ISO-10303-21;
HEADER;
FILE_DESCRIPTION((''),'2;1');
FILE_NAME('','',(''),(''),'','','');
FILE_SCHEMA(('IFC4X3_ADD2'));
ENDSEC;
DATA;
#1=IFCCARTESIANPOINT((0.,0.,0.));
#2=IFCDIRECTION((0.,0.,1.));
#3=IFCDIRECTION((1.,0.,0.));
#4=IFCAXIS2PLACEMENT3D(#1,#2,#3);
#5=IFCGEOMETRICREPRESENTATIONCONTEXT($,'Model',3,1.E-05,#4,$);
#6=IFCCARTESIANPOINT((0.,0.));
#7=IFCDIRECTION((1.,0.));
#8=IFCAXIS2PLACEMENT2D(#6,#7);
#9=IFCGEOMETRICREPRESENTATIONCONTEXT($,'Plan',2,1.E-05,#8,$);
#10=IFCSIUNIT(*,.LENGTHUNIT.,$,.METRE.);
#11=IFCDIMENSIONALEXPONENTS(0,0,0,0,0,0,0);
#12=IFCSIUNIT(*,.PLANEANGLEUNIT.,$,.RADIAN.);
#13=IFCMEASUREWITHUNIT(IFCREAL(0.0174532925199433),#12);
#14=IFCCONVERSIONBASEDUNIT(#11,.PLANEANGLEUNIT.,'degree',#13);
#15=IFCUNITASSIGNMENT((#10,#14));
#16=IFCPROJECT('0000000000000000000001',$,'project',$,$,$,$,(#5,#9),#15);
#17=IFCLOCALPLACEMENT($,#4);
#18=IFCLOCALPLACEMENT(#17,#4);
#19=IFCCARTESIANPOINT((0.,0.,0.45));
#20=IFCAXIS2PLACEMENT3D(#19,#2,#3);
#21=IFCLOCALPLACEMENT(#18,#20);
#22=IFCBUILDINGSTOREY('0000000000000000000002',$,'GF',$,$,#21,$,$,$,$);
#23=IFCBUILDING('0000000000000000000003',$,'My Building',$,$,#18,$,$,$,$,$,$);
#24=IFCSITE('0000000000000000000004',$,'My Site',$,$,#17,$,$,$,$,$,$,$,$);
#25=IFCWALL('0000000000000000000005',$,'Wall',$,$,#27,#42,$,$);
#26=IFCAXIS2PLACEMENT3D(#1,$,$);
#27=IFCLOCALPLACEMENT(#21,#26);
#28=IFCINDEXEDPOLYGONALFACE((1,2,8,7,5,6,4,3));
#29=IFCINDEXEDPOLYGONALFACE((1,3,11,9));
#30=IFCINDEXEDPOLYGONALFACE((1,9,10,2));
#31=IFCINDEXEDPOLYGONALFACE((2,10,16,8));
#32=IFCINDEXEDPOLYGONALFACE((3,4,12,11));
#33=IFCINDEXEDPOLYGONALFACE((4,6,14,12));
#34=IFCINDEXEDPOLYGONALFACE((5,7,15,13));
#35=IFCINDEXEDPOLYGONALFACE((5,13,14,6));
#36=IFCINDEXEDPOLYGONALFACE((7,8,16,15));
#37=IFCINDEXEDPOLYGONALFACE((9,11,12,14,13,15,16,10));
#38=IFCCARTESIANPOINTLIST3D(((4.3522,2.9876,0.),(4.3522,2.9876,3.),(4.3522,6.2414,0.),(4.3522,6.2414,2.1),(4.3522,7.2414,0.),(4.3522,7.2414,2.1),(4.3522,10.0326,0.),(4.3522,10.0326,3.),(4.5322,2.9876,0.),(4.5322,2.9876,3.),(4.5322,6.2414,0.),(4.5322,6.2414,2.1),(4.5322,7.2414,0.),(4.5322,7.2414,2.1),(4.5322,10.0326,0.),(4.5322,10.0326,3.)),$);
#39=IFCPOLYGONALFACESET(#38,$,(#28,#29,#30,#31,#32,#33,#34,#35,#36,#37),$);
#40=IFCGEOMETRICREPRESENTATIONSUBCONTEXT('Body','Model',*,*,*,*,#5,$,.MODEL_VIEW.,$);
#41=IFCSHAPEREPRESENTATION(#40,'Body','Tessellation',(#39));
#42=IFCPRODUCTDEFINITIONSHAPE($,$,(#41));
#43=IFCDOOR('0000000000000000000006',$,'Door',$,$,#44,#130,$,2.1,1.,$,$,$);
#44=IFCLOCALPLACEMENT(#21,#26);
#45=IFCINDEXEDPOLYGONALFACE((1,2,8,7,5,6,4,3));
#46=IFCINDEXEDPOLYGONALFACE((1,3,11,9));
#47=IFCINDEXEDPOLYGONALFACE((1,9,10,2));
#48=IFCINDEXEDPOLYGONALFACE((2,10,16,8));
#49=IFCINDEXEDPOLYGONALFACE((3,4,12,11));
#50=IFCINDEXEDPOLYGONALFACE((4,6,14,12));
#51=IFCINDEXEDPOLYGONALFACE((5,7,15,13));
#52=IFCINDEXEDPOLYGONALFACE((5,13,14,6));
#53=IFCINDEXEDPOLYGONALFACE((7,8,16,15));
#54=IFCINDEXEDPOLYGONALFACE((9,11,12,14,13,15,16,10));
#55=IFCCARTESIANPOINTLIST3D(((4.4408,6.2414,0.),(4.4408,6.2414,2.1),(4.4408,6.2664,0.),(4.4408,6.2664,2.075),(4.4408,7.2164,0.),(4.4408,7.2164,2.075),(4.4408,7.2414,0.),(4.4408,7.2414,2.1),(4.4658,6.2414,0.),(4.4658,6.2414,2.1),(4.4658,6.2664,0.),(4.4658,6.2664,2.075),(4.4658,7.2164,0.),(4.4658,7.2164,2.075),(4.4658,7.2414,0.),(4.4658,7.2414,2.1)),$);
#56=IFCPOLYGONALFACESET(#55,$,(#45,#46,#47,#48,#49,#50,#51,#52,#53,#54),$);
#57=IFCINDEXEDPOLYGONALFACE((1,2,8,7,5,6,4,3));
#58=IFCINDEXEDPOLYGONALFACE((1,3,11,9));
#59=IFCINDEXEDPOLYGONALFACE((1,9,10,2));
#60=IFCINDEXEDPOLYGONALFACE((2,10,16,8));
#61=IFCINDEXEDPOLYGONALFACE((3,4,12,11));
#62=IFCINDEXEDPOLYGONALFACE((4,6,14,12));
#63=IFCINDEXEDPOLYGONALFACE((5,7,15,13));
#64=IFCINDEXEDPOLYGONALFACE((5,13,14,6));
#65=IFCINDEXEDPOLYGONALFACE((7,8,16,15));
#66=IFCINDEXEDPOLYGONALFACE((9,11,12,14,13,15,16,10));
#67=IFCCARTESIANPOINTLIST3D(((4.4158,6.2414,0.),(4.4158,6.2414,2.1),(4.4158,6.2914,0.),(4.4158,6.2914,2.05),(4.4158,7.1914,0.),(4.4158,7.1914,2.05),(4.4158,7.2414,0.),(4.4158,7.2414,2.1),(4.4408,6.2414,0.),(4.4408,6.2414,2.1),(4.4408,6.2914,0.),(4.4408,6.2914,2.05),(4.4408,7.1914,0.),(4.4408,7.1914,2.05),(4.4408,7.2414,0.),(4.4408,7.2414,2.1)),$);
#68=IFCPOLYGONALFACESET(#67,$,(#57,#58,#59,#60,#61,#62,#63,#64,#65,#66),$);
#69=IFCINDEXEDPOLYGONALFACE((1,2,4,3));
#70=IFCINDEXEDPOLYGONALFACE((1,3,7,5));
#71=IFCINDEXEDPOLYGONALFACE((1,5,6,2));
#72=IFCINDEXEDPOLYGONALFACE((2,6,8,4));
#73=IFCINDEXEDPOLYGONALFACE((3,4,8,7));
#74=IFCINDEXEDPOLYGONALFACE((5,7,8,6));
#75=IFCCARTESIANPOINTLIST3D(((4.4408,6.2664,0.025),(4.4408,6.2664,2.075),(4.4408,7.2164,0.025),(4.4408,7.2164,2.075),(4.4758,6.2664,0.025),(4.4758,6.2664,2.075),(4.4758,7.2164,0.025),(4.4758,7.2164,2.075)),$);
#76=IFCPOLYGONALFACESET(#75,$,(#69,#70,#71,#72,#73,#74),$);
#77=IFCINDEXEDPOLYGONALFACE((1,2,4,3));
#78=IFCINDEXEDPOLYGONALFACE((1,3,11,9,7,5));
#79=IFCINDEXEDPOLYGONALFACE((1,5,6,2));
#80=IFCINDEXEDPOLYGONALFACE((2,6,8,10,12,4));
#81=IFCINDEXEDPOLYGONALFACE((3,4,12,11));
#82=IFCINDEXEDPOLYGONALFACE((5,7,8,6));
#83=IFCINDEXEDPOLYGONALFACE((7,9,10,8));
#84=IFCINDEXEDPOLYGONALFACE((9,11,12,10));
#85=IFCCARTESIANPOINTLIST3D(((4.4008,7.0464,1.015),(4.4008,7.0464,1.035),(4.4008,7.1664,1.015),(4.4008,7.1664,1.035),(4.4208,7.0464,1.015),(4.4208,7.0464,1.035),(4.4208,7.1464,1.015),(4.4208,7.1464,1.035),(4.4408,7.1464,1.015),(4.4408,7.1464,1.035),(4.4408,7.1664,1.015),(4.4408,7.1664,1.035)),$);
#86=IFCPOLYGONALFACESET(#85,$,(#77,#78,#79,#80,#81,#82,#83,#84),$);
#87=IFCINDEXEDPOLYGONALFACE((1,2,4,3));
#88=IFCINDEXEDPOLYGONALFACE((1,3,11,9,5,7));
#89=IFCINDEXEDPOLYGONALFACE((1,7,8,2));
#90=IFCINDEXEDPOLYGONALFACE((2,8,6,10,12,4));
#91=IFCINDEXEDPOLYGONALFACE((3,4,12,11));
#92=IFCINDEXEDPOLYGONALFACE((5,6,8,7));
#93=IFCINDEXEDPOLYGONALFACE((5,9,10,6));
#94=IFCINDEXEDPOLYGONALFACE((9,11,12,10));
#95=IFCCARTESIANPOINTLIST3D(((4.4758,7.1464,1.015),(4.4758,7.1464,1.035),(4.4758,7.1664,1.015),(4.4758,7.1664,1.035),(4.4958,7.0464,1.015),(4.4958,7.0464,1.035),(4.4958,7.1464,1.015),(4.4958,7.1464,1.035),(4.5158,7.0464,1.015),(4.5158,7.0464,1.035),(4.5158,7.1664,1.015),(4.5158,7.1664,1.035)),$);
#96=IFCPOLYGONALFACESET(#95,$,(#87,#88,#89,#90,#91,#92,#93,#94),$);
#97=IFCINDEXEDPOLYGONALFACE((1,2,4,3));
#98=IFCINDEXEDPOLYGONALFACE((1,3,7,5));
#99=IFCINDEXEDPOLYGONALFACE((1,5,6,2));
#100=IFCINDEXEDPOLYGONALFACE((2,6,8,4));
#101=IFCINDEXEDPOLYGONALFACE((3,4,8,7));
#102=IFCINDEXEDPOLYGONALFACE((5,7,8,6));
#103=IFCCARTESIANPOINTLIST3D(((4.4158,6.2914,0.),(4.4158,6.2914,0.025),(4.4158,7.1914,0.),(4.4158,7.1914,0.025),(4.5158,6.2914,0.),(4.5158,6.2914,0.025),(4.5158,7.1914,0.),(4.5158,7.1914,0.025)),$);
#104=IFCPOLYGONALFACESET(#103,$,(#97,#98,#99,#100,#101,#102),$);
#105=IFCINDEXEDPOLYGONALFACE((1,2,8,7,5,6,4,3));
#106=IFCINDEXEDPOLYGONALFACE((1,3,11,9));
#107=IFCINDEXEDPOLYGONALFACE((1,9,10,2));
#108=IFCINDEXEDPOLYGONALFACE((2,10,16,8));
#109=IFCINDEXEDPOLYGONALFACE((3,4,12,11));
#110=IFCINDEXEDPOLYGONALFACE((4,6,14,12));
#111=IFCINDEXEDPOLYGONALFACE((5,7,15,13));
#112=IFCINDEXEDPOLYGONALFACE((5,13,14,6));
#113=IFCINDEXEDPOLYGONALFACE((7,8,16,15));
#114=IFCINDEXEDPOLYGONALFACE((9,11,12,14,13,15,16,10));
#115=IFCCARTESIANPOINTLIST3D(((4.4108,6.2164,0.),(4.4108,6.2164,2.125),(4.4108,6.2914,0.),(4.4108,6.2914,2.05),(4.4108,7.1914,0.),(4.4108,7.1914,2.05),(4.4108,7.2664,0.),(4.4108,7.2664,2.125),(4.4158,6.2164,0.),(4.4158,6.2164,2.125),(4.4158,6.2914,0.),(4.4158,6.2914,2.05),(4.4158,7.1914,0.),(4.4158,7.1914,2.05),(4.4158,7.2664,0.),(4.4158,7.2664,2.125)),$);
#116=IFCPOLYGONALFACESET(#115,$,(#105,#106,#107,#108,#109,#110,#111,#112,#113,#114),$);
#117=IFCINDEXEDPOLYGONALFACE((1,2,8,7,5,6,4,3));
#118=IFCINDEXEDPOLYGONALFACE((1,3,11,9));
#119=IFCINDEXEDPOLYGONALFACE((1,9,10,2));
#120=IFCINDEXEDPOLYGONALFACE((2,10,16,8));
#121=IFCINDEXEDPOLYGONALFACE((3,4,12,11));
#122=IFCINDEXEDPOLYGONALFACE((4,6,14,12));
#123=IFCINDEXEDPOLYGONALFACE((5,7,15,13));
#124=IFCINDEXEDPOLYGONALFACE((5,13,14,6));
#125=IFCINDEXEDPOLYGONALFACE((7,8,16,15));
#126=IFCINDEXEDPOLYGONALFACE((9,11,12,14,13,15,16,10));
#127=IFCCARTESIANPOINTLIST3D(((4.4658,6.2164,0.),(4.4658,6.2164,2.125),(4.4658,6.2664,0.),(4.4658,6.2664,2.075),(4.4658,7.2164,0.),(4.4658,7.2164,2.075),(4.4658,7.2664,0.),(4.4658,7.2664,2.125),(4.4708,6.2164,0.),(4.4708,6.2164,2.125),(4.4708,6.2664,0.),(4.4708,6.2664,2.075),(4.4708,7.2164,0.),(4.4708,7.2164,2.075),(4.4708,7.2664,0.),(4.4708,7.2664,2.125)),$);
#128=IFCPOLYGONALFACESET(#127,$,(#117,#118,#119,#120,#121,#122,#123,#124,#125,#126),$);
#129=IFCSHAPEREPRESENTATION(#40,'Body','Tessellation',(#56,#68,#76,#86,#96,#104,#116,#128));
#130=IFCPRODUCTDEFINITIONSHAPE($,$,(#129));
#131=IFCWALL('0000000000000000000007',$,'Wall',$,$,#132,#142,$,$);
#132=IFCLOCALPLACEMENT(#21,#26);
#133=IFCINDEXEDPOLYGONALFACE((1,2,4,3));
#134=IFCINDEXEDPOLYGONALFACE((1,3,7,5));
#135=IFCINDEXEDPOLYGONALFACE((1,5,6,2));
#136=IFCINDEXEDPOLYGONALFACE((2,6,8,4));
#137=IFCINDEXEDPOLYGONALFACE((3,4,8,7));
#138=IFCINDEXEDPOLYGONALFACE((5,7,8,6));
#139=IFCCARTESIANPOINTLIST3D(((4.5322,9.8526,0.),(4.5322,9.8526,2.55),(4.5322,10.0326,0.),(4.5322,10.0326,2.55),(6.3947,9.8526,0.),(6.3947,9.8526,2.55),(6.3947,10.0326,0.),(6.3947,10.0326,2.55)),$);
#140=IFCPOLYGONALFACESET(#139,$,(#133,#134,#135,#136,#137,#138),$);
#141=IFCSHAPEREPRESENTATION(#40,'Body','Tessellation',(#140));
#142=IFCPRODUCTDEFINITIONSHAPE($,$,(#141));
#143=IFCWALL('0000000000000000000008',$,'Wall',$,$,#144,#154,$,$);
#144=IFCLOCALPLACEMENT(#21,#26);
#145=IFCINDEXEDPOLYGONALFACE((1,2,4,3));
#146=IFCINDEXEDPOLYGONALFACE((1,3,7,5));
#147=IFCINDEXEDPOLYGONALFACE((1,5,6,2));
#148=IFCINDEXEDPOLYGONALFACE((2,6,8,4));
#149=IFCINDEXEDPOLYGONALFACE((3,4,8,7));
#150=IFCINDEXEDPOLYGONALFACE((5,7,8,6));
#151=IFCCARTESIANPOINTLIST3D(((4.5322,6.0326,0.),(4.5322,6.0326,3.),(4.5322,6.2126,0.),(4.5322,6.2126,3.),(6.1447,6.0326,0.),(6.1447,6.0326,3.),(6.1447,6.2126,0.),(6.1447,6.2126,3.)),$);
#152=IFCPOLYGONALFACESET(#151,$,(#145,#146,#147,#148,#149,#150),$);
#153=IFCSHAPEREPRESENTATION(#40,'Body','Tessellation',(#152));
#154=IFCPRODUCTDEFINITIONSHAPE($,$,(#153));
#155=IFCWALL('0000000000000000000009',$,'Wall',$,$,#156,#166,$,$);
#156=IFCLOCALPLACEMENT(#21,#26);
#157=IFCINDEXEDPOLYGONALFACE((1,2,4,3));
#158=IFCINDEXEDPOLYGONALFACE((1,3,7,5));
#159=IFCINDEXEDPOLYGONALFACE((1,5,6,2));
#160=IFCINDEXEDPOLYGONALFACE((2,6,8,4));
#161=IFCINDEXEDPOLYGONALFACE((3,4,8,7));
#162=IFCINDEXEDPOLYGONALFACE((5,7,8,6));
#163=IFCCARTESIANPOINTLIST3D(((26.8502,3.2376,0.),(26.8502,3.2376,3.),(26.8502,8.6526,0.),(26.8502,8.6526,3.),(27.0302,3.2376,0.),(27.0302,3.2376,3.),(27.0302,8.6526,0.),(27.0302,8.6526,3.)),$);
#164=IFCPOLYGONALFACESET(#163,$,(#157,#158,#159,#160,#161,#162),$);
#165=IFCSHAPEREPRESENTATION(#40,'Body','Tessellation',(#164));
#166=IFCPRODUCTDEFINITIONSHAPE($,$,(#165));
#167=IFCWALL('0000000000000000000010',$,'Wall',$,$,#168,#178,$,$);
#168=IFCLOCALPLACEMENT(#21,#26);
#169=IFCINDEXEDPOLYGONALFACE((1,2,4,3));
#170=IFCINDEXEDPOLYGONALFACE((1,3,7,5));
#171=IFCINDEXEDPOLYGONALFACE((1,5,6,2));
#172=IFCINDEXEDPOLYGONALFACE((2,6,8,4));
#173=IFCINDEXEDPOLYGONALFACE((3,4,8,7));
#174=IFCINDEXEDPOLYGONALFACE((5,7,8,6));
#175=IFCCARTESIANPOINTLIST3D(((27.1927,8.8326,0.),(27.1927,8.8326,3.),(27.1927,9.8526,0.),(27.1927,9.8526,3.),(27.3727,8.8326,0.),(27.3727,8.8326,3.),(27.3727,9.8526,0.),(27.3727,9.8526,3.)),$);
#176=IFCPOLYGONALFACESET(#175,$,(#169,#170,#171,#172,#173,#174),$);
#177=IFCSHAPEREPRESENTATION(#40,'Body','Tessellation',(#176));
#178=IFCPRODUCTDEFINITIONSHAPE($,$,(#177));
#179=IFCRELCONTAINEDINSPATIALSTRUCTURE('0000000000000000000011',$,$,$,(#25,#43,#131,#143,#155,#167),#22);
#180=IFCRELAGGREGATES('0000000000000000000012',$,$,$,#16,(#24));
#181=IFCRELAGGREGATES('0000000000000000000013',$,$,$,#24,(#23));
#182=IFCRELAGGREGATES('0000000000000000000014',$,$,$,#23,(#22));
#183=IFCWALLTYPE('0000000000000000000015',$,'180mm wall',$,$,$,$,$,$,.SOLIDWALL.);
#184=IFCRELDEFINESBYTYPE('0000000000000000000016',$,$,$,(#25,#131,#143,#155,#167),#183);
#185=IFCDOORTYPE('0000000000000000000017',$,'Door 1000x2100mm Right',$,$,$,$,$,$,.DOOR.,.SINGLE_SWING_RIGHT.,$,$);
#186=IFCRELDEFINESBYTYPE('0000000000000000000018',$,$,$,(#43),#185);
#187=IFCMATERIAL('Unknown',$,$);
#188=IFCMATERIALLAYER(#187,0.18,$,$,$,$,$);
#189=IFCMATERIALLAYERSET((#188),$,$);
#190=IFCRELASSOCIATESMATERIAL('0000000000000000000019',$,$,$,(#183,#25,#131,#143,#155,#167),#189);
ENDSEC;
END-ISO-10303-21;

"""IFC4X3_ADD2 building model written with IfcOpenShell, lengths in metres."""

from ifc_helpers import new_model, entity, si_unit, converted_unit, frame, origin_with_axes, origin_2d_with_axis, place, context, subcontext, project, spatial, line, indexed_curve, outline, extrude, clip, halfspace, shape, source, transform, mapped, material, layer, layer_set, layer_usage, type_object, type_shapes, element, fill, save


model = new_model("IFC4X3_ADD2")

# Units and contexts
model_context = context("Model", 3, precision=1e-05, world=origin_with_axes())
plan_context = context("Plan", 2, precision=1e-05, world=origin_2d_with_axis())
body_context_1 = subcontext(model_context, "Body", "Model", "MODEL_VIEW")
body_context_2 = subcontext(plan_context, "Body", "Plan", "PLAN_VIEW")
ifc_project = project(units=[si_unit("LENGTHUNIT", "METRE"), converted_unit("PLANEANGLEUNIT", "degree", entity("IfcReal", 0.0174532925199433), si_unit("PLANEANGLEUNIT", "RADIAN"), dimensions=[0, 0, 0, 0, 0, 0, 0])], contexts=[model_context, plan_context])

# Site, building, storey
site_placement = place(None, origin_with_axes())
site = spatial("IfcSite", under=ifc_project, at=site_placement, Name="My Site")
building_placement = place(site_placement, origin_with_axes())
building = spatial("IfcBuilding", under=site, at=building_placement, Name="My Building")
storey_placement = place(building_placement, frame((0.0, 0.0, 0.45), z_axis=(0.0, 0.0, 1.0), x_axis=(1.0, 0.0, 0.0)))
storey = spatial("IfcBuildingStorey", under=building, at=storey_placement, Name="GF")

# Shared definitions
ifc_material_1 = material(Name="Unknown")

# Wall, opening, door
ifc_layer_1 = layer(ifc_material_1, 0.18)
ifc_layer_set_1 = layer_set([ifc_layer_1])
ifc_layer_usage_1 = layer_usage(ifc_layer_set_1, "AXIS2", "POSITIVE", 0.0)
wall_type_1 = type_object("IfcWallType", Name="180mm wall", PredefinedType="SOLIDWALL", material=ifc_layer_set_1)
wall_1_placement = place(storey_placement, frame((4.5322, 2.9876, 0.0), z_axis=(0.0, 0.0, 1.0), x_axis=(0.0, 1.0, 0.0)))
wall_1 = element("IfcWall", 1, at=wall_1_placement, inside=storey, type_object=wall_type_1, material=ifc_layer_usage_1, Name="Wall", context=body_context_1, shape_type="SweptSolid", body=[
    extrude(outline(indexed_curve([(0.0, 0.0), (0.0, 0.18), (7.045, 0.18), (7.045, 0.0), (0.0, 0.0)], self_intersect=False)), origin_with_axes(), (0.0, 0.0, 1.0), 3.0),
])
shared_shape_1 = source(origin_with_axes(), body_context_1, "Body", "SolidModel", [
    extrude(outline(indexed_curve([(0.0, 0.0), (1.0, 0.0), (1.0, 2.1), (0.0, 2.1)], segments=[line(1, 2, 3, 4, 1)])), frame((0.0, -0.6, 0.0), z_axis=(0.0, -1.0, 0.0), x_axis=(1.0, 0.0, 0.0)), (0.0, 0.0, -1.0), 1.2),
])
opening_1_placement = place(wall_1_placement, frame((4.2539, 0.1164, 0.0), z_axis=(0.0, 0.0, 1.0), x_axis=(-1.0, 0.0, 0.0)))
opening_1 = element("IfcOpeningElement", 2, at=opening_1_placement, cuts=wall_1, PredefinedType="OPENING", context=body_context_1, shape_type="MappedRepresentation", body=[
    mapped(shared_shape_1, transform((0.0, 0.0, 0.0), x_axis=(1.0, 0.0, 0.0), y_axis=(0.0, 1.0, 0.0), z_axis=(0.0, 0.0, 1.0), scale=1.0)),
])
door_type_1 = type_object("IfcDoorType", Name="Door 1000x2100mm Right", OperationType="SINGLE_SWING_RIGHT", PredefinedType="DOOR")
shared_shape_2 = source(origin_with_axes(), body_context_1, "Body", "SweptSolid", [
    extrude(outline(indexed_curve([(0.0, 0.0), (0.0, 2.1), (1.0, 2.1), (1.0, 0.0), (0.975, 0.0), (0.975, 2.075), (0.025, 2.075), (0.025, 0.0)], segments=[line(1, 2, 3, 4, 5, 6, 7, 8, 1)])), frame((0.0, 0.025, 0.0), z_axis=(0.0, -1.0, 0.0), x_axis=(1.0, 0.0, 0.0)), (0.0, 0.0, -1.0), 0.025),
    extrude(outline(indexed_curve([(0.0, 0.0), (0.0, 2.1), (1.0, 2.1), (1.0, 0.0), (0.95, 0.0), (0.95, 2.05), (0.05, 2.05), (0.05, 0.0)], segments=[line(1, 2, 3, 4, 5, 6, 7, 8, 1)])), frame((0.0, 0.0, 0.0), z_axis=(0.0, -1.0, 0.0), x_axis=(1.0, 0.0, 0.0)), (0.0, 0.0, -1.0), 0.025),
    extrude(outline(indexed_curve([(0.0, 0.0), (0.95, 0.0), (0.95, 0.035), (0.0, 0.035)], segments=[line(1, 2, 3, 4, 1)])), frame((0.025, 0.025, 0.025), z_axis=(0.0, 0.0, 1.0), x_axis=(1.0, 0.0, 0.0)), (0.0, 0.0, 1.0), 2.05),
    extrude(outline(indexed_curve([(0.0, 0.0), (0.0, -0.04), (0.12, -0.04), (0.12, -0.02), (0.02, -0.02), (0.02, 0.0)], segments=[line(1, 2, 3, 4, 5, 6, 1)])), frame((0.075, 0.025, 1.015), z_axis=(0.0, 0.0, 1.0), x_axis=(1.0, 0.0, 0.0)), (0.0, 0.0, 1.0), 0.02),
    extrude(outline(indexed_curve([(0.0, 0.0), (0.0, 0.04), (0.12, 0.04), (0.12, 0.02), (0.02, 0.02), (0.02, 0.0)], segments=[line(1, 2, 3, 4, 5, 6, 1)])), frame((0.075, 0.06, 1.015), z_axis=(0.0, 0.0, 1.0), x_axis=(1.0, 0.0, 0.0)), (0.0, 0.0, 1.0), 0.02),
    extrude(outline(indexed_curve([(0.0, 0.0), (0.9, 0.0), (0.9, 0.1), (0.0, 0.1)], segments=[line(1, 2, 3, 4, 1)])), frame((0.05, 0.0, 0.0), z_axis=(0.0, 0.0, 1.0), x_axis=(1.0, 0.0, 0.0)), (0.0, 0.0, 1.0), 0.025),
    extrude(outline(indexed_curve([(0.0, 0.0), (0.0, 2.125), (1.05, 2.125), (1.05, 0.0), (0.975, 0.0), (0.975, 2.05), (0.075, 2.05), (0.075, 0.0)], segments=[line(1, 2, 3, 4, 5, 6, 7, 8, 1)])), frame((-0.025, -0.005, 0.0), z_axis=(0.0, -1.0, 0.0), x_axis=(1.0, 0.0, 0.0)), (0.0, 0.0, -1.0), 0.005),
    extrude(outline(indexed_curve([(0.0, 0.0), (0.0, 2.125), (1.05, 2.125), (1.05, 0.0), (1.0, 0.0), (1.0, 2.075), (0.05, 2.075), (0.05, 0.0)], segments=[line(1, 2, 3, 4, 5, 6, 7, 8, 1)])), frame((-0.025, 0.05, 0.0), z_axis=(0.0, -1.0, 0.0), x_axis=(1.0, 0.0, 0.0)), (0.0, 0.0, -1.0), 0.005),
])
shared_shape_3 = source(origin_with_axes(), body_context_2, "Body", "Curve2D", [
    entity("IfcIndexedPolyCurve", entity("IfcCartesianPointList2D", [[0.0, 0.0], [0.0, 0.05], [0.025, 0.05], [0.025, 0.025], [0.05, 0.025], [0.05, 0.0]]), [entity("IfcLineIndex", [1, 2, 3, 4, 5, 6, 1])]),
    entity("IfcIndexedPolyCurve", entity("IfcCartesianPointList2D", [[1.0, 0.0], [1.0, 0.05], [0.975, 0.05], [0.975, 0.025], [0.95, 0.025], [0.95, 0.0]]), [entity("IfcLineIndex", [1, 2, 3, 4, 5, 6, 1])]),
    entity("IfcTrimmedCurve", entity("IfcEllipse", entity("IfcAxis2Placement2D", entity("IfcCartesianPoint", [0.94, 0.05]), entity("IfcDirection", [1.0, 0.0])), 0.915, 0.95), [entity("IfcCartesianPoint", [0.94, 1.0])], [entity("IfcCartesianPoint", [0.025, 0.05])], True, "CARTESIAN"),
    entity("IfcIndexedPolyCurve", entity("IfcCartesianPointList2D", [[0.975, 0.05], [0.94, 0.05], [0.94, 1.0], [0.975, 1.0]]), [entity("IfcLineIndex", [1, 2, 3, 4, 1])]),
])
type_shapes(door_type_1, [shared_shape_2, shared_shape_3])
door_1_placement = place(opening_1_placement, frame((0.0, 0.0, 0.0), z_axis=(0.0, 0.0, 1.0), x_axis=(1.0, 0.0, 0.0)))
door_1 = element("IfcDoor", 3, at=door_1_placement, inside=storey, type_object=door_type_1, Name="Door", OverallHeight=2.1, OverallWidth=1.0, shapes=[
    shape(body_context_1, "Body", "MappedRepresentation", [mapped(shared_shape_2, transform((0.0, 0.0, 0.0), x_axis=(1.0, 0.0, 0.0), y_axis=(0.0, 1.0, 0.0), z_axis=(0.0, 0.0, 1.0), scale=1.0))]),
    shape(body_context_2, "Body", "MappedRepresentation", [mapped(shared_shape_3, transform((0.0, 0.0, 0.0), x_axis=(1.0, 0.0, 0.0), y_axis=(0.0, 1.0, 0.0), z_axis=(0.0, 0.0, 1.0), scale=1.0))]),
])
fill(opening_1, door_1)

# Walls
ifc_layer_usage_2 = layer_usage(ifc_layer_set_1, "AXIS2", "POSITIVE", 0.0)
wall_2_placement = place(storey_placement, frame((6.3947, 10.0326, 0.0), z_axis=(0.0, 0.0, 1.0), x_axis=(-1.0, 0.0, 0.0)))
element("IfcWall", 4, at=wall_2_placement, inside=storey, type_object=wall_type_1, material=ifc_layer_usage_2, Name="Wall", context=body_context_1, shape_type="Clipping", body=[
    clip(extrude(outline(indexed_curve([(0.0, 0.0), (0.0, 0.18), (1.8625, 0.18), (1.8625, 0.0), (0.0, 0.0)], self_intersect=False)), origin_with_axes(), (0.0, 0.0, 1.0), 2.55), halfspace(frame((0.0, 0.0, 2.55), z_axis=(0.0, 0.0, 1.0), x_axis=(-1.0, 0.0, 0.0)), False)),
])
ifc_layer_usage_3 = layer_usage(ifc_layer_set_1, "AXIS2", "POSITIVE", 0.0)
wall_3_placement = place(storey_placement, frame((6.1447, 6.2126, 0.0), z_axis=(0.0, 0.0, 1.0), x_axis=(-1.0, 0.0, 0.0)))
element("IfcWall", 5, at=wall_3_placement, inside=storey, type_object=wall_type_1, material=ifc_layer_usage_3, Name="Wall", context=body_context_1, shape_type="SweptSolid", body=[
    extrude(outline(indexed_curve([(0.0, 0.0), (0.0, 0.18), (1.6125, 0.18), (1.6125, 0.0), (0.0, 0.0)], self_intersect=False)), origin_with_axes(), (0.0, 0.0, 1.0), 3.0),
])
ifc_layer_usage_4 = layer_usage(ifc_layer_set_1, "AXIS2", "POSITIVE", 0.0)
wall_4_placement = place(storey_placement, frame((27.0302, 3.2376, 0.0), z_axis=(0.0, 0.0, 1.0), x_axis=(0.0, 1.0, 0.0)))
element("IfcWall", 6, at=wall_4_placement, inside=storey, type_object=wall_type_1, material=ifc_layer_usage_4, Name="Wall", context=body_context_1, shape_type="SweptSolid", body=[
    extrude(outline(indexed_curve([(0.0, 0.0), (0.0, 0.18), (5.415, 0.18), (5.415, 0.0), (0.0, 0.0)], self_intersect=False)), origin_with_axes(), (0.0, 0.0, 1.0), 3.0),
])
ifc_layer_usage_5 = layer_usage(ifc_layer_set_1, "AXIS2", "POSITIVE", 0.0)
wall_5_placement = place(storey_placement, frame((27.3727, 8.8326, 0.0), z_axis=(0.0, 0.0, 1.0), x_axis=(0.0, 1.0, 0.0)))
element("IfcWall", 7, at=wall_5_placement, inside=storey, type_object=wall_type_1, material=ifc_layer_usage_5, Name="Wall", context=body_context_1, shape_type="SweptSolid", body=[
    extrude(outline(indexed_curve([(0.0, 0.0), (0.0, 0.18), (1.02, 0.18), (1.02, 0.0), (0.0, 0.0)], self_intersect=False)), origin_with_axes(), (0.0, 0.0, 1.0), 3.0),
])

save(model, "model.ifc")
